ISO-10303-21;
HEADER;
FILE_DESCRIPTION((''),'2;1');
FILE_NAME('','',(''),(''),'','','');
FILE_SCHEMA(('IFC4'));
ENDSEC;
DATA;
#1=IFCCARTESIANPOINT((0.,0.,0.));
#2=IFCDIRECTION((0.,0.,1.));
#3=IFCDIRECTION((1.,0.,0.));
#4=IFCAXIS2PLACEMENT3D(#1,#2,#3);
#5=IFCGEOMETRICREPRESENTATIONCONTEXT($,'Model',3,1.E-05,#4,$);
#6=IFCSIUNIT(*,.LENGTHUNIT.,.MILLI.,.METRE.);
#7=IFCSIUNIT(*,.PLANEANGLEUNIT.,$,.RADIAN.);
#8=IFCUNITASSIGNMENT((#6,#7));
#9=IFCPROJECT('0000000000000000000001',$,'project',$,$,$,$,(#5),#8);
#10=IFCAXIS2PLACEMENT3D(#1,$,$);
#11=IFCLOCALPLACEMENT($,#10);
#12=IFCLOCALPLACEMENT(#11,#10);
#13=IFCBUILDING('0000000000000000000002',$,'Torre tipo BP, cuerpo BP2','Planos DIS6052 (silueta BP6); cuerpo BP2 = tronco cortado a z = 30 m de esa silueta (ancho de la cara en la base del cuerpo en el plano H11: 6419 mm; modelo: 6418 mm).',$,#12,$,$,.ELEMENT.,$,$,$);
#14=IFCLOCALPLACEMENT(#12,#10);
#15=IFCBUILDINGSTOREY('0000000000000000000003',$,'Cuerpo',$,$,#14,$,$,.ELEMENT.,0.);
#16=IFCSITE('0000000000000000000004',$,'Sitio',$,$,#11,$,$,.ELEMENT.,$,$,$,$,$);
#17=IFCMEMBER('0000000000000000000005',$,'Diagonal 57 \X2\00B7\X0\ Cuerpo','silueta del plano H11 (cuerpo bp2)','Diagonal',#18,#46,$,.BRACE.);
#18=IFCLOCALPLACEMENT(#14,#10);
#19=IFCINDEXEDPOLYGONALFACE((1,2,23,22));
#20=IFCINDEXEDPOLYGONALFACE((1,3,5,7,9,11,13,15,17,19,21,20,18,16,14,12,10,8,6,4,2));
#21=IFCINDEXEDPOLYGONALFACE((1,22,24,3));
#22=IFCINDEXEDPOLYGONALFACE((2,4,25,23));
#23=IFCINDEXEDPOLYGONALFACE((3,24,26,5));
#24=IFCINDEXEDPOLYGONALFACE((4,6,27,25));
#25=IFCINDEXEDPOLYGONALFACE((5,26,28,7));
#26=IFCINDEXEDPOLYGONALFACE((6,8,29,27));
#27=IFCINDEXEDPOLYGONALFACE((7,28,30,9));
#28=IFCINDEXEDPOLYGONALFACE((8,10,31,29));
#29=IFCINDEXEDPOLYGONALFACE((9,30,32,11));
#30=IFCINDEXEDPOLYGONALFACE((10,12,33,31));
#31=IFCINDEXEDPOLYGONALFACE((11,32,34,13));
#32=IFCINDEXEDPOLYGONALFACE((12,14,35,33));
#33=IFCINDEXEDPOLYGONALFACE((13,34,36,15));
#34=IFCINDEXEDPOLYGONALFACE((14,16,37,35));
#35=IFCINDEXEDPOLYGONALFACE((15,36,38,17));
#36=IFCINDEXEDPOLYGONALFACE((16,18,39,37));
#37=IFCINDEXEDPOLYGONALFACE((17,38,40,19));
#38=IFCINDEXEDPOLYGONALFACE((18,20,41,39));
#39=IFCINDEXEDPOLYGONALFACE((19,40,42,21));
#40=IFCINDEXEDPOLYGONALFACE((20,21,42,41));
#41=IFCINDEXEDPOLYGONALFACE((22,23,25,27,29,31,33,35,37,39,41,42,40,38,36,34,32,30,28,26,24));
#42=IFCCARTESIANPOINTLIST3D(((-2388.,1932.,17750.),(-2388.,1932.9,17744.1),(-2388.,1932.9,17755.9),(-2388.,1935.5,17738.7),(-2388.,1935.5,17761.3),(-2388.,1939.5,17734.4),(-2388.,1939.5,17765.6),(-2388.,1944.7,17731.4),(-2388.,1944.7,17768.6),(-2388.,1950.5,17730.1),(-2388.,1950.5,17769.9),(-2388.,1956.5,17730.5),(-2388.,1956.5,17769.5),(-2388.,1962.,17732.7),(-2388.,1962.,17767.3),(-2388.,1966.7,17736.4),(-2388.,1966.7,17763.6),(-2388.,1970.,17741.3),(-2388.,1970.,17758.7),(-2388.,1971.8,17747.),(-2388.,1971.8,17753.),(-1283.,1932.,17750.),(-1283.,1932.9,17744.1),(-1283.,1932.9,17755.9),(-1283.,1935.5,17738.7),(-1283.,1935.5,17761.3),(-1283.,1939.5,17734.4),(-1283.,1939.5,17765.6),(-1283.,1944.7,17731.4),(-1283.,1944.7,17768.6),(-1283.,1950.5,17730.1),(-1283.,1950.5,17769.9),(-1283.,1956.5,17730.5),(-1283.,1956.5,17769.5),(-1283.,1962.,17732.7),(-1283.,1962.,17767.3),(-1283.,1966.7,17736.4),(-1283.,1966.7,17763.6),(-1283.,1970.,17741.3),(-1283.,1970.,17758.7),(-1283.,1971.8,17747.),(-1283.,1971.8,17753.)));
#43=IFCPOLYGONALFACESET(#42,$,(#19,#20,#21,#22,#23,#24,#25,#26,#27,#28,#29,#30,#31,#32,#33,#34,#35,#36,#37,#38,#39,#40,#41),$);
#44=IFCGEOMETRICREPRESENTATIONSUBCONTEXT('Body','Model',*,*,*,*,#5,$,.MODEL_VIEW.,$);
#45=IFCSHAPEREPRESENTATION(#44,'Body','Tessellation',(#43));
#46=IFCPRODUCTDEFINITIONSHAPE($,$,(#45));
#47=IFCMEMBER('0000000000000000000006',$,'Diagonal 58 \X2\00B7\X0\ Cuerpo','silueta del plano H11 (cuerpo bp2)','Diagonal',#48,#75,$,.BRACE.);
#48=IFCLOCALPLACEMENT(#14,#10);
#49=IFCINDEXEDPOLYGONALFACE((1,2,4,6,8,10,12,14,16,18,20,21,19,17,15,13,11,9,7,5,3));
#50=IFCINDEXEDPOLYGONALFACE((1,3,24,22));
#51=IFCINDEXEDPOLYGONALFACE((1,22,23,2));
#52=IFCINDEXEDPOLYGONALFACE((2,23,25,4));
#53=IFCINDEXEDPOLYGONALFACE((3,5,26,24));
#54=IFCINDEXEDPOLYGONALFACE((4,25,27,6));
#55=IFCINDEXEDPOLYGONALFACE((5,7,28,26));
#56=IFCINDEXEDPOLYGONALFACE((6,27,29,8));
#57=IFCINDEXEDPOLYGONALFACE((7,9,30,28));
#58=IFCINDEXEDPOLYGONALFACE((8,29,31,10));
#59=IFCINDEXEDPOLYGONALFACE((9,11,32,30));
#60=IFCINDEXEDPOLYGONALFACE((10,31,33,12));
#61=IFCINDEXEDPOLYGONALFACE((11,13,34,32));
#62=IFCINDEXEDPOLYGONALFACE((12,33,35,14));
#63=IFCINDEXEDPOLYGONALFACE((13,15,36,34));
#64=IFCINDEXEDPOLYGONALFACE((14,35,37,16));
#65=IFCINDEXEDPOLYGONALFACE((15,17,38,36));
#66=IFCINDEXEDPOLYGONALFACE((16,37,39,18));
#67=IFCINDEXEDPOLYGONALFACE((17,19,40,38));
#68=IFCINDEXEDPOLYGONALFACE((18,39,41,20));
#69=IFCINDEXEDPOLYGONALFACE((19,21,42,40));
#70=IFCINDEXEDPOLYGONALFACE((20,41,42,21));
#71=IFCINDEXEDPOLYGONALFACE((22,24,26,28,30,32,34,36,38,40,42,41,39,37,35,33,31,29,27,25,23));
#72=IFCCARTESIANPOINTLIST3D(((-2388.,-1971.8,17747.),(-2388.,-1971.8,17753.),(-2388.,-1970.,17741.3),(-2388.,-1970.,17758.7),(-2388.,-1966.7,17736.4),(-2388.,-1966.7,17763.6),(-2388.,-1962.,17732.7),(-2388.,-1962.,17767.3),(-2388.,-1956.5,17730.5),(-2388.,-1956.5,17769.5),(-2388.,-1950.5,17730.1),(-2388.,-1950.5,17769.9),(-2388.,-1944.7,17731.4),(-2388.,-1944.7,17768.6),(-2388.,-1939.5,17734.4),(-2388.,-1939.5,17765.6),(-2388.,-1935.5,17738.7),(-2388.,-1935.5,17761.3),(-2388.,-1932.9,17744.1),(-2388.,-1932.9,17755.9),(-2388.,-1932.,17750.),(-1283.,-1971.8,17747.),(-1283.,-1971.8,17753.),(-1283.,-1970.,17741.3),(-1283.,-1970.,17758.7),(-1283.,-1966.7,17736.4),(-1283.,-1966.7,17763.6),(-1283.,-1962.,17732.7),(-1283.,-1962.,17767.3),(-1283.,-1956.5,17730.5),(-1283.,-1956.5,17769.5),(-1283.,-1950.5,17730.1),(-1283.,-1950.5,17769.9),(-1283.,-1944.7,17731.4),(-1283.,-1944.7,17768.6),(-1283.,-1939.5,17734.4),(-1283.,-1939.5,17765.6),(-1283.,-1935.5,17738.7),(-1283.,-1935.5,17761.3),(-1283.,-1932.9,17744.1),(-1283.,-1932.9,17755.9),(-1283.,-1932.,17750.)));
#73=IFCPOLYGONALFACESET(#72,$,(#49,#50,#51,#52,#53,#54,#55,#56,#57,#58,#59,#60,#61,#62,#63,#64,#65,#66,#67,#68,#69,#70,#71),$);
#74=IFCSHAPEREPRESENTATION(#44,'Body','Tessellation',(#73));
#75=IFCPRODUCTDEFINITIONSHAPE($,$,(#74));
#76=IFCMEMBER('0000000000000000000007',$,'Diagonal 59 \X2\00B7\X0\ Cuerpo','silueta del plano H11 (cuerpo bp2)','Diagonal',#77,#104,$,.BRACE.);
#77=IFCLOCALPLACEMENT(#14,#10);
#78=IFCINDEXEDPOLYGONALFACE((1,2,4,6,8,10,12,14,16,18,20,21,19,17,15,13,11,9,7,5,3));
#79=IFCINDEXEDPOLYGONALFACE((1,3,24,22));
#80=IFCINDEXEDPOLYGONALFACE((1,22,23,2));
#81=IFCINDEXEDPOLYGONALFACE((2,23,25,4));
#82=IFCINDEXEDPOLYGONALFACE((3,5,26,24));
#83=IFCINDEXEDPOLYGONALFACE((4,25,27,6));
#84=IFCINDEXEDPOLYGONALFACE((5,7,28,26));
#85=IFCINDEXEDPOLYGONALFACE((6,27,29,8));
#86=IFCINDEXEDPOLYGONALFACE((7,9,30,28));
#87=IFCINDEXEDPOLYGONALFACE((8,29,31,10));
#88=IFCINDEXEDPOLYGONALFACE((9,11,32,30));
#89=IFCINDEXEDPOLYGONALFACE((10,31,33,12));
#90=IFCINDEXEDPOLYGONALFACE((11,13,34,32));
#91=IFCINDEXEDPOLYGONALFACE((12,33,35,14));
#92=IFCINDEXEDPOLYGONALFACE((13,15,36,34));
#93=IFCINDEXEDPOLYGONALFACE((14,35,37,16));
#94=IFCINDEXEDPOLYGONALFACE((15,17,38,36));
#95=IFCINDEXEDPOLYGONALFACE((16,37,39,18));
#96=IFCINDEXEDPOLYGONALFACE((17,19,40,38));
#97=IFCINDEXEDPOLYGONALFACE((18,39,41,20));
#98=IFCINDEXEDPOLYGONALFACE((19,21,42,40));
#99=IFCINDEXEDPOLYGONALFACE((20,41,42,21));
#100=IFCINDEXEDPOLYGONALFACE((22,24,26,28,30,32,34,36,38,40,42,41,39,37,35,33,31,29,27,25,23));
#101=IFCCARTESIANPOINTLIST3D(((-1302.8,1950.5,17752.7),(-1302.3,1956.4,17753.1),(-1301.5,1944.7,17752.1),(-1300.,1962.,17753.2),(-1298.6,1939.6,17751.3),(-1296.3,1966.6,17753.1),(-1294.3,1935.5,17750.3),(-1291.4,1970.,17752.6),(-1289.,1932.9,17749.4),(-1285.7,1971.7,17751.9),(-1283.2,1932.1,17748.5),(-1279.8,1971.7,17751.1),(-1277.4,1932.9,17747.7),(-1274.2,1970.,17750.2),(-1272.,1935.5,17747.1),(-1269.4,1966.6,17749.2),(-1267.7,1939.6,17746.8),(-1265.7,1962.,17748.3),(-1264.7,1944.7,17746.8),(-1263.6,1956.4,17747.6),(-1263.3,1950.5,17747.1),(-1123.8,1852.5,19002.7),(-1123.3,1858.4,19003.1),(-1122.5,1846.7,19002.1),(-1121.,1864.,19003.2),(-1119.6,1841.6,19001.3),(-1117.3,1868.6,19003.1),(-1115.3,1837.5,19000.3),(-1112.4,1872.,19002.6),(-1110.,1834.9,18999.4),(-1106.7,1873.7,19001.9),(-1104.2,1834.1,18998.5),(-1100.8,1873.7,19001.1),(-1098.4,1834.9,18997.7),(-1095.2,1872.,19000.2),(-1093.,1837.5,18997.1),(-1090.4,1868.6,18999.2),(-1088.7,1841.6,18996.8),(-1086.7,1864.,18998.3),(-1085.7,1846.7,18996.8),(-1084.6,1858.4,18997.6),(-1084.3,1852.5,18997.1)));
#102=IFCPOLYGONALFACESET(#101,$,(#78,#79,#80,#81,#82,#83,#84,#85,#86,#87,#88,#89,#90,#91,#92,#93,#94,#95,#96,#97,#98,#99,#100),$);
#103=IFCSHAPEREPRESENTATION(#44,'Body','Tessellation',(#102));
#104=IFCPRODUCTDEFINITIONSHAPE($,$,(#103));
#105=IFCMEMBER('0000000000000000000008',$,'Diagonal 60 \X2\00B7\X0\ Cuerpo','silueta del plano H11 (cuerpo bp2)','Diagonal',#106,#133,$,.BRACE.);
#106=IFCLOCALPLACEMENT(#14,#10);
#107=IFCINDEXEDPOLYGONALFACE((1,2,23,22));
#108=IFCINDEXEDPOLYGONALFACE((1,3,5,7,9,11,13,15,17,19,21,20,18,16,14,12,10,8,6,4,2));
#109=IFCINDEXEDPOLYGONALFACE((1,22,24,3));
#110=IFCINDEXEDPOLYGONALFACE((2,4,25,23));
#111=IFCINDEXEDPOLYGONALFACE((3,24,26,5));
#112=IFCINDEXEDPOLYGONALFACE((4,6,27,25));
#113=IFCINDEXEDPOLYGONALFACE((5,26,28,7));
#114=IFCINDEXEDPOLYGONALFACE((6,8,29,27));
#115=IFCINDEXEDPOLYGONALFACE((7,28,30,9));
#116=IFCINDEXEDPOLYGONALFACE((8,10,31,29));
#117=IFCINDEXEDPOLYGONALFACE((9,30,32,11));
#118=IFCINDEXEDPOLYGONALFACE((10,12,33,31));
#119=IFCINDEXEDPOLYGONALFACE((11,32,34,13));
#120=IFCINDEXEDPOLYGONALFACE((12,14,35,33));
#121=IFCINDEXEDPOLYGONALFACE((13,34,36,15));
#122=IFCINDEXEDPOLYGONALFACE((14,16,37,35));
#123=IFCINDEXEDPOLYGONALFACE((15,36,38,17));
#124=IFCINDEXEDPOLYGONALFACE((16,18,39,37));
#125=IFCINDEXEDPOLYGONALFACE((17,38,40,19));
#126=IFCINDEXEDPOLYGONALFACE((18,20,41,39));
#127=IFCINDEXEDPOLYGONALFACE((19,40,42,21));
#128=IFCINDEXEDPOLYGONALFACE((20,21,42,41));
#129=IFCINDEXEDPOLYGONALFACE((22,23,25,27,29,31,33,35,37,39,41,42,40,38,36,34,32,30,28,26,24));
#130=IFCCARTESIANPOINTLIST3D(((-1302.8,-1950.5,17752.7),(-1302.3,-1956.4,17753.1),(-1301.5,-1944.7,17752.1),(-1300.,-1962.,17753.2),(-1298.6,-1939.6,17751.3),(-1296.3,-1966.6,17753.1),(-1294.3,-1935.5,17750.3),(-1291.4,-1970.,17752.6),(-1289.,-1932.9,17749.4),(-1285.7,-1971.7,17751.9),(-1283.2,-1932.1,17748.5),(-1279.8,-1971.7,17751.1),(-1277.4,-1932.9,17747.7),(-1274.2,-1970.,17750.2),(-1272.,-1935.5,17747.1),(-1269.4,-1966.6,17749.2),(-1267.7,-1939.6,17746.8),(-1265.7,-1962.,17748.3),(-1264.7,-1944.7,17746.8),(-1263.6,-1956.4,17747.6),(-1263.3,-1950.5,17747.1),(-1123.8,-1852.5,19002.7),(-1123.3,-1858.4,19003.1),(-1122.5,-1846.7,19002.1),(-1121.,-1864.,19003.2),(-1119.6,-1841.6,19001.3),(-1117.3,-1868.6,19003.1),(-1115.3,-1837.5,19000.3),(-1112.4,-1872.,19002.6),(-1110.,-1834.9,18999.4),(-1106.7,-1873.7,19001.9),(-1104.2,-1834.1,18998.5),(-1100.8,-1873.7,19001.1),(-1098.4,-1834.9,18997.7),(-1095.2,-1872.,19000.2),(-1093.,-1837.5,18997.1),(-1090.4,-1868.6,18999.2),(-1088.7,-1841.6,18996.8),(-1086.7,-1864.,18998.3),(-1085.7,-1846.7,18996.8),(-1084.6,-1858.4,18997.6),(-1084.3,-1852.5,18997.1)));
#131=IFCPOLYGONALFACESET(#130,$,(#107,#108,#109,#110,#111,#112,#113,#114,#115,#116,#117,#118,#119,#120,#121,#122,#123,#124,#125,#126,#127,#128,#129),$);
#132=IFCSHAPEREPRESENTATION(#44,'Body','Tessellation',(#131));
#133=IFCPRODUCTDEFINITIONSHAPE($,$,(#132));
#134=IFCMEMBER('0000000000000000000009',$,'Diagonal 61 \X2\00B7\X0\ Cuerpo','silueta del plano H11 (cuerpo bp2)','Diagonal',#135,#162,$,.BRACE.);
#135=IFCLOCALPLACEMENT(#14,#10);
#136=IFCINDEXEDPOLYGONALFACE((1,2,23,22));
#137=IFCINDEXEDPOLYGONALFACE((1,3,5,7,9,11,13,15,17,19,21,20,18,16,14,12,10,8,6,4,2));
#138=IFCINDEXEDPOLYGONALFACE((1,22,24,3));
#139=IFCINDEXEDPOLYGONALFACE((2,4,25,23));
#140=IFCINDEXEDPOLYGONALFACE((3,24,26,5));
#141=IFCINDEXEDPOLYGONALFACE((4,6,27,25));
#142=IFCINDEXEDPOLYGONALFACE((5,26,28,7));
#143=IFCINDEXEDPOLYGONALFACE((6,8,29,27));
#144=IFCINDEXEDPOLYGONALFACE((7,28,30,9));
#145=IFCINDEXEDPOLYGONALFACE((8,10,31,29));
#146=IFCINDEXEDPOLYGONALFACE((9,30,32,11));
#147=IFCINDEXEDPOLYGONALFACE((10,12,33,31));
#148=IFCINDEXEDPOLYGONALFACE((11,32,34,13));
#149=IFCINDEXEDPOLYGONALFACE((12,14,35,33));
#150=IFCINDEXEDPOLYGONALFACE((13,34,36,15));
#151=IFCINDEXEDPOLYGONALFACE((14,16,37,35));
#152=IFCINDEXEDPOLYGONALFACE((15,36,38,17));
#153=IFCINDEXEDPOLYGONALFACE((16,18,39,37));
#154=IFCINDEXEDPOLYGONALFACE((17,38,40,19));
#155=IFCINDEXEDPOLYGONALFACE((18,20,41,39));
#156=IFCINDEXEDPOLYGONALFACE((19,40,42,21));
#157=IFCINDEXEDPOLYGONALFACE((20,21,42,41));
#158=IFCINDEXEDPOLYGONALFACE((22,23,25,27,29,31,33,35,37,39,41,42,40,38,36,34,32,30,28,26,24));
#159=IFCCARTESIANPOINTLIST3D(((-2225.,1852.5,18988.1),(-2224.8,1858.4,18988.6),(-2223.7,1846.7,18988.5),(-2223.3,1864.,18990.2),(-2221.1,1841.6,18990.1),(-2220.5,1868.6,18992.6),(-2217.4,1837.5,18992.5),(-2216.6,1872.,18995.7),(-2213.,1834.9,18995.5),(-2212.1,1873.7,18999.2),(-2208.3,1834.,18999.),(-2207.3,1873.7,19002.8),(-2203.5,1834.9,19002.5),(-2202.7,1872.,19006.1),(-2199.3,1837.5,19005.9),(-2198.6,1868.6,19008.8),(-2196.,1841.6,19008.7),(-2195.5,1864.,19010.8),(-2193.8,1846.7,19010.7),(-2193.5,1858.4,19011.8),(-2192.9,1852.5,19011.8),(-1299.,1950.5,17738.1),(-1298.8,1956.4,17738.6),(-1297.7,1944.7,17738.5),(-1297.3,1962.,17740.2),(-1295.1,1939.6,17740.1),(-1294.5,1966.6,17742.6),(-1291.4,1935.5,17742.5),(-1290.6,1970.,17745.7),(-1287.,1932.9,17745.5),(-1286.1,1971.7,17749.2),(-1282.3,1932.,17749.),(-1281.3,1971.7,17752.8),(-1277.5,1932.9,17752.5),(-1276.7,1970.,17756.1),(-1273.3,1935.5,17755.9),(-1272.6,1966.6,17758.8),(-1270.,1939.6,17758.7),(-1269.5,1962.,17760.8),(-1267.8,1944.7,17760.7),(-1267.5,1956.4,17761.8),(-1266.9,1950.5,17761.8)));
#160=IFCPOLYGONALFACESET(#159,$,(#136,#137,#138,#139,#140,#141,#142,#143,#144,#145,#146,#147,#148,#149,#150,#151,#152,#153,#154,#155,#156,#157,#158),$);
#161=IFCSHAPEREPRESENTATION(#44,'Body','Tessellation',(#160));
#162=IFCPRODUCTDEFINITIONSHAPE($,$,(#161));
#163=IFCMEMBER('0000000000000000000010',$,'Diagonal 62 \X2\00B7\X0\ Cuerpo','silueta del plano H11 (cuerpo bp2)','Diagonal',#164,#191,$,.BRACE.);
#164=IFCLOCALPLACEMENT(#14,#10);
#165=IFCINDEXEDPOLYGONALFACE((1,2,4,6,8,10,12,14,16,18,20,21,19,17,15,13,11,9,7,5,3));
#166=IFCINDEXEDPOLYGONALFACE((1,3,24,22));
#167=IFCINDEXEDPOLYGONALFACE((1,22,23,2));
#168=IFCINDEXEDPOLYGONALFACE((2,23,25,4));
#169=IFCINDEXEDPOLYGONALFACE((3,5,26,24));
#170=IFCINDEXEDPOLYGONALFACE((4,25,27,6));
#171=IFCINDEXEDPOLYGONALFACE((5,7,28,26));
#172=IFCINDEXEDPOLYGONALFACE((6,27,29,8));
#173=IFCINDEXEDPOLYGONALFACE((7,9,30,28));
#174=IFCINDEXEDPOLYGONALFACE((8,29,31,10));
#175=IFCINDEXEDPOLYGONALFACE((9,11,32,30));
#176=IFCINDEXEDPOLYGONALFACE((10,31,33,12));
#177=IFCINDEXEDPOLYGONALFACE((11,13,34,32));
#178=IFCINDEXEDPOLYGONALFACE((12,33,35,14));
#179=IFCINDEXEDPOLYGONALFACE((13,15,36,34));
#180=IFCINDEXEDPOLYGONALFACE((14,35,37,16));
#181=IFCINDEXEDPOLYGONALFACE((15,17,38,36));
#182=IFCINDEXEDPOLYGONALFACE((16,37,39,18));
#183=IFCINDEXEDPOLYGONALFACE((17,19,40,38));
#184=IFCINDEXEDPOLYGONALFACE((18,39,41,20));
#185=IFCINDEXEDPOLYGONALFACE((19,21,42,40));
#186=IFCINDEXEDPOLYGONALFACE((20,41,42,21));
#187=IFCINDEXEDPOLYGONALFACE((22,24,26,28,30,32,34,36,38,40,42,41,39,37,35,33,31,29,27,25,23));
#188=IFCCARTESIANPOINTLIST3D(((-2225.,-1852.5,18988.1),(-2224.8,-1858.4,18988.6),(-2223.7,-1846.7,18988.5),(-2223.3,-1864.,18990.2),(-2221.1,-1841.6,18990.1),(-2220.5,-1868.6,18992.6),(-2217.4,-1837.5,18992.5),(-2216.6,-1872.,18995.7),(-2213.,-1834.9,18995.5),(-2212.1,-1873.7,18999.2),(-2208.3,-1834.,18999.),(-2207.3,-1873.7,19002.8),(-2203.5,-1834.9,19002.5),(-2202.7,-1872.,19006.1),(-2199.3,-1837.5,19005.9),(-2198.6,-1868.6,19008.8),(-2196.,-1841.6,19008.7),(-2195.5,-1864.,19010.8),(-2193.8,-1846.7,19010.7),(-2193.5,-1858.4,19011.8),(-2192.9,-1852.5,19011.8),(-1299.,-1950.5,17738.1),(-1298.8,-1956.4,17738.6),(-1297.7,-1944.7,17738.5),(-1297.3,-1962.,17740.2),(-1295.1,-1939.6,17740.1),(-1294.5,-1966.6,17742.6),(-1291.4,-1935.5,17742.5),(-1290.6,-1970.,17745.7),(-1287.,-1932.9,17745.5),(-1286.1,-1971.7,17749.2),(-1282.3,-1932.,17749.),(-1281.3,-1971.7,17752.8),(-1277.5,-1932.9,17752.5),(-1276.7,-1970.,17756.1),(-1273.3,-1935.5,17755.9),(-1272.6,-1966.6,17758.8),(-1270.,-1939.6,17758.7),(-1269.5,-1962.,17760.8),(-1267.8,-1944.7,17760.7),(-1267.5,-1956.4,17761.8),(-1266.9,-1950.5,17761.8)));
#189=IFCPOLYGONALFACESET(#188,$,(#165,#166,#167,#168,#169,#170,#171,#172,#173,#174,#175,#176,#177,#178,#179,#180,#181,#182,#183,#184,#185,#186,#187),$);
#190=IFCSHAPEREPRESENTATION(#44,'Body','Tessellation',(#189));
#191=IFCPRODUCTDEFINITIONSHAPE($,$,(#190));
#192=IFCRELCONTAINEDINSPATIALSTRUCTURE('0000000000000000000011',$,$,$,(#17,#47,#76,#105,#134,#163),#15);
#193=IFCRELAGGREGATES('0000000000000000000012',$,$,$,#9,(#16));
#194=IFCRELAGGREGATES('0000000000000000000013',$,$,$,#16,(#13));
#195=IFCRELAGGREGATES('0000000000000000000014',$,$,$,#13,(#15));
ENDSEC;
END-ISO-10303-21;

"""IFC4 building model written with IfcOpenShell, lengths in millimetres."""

from ifc_helpers import new_model, si_unit, frame, origin, origin_with_axes, place, context, subcontext, project, spatial, circle, extrude, element, save


model = new_model("IFC4")

# Units and contexts
model_context = context("Model", 3, precision=1e-05, world=origin_with_axes())
body_context = subcontext(model_context, "Body", "Model", "MODEL_VIEW")
ifc_project = project(units=[si_unit("LENGTHUNIT", "METRE", prefix="MILLI"), si_unit("PLANEANGLEUNIT", "RADIAN")], contexts=[model_context])

# Site, building, storey
site_placement = place(None, origin())
site = spatial("IfcSite", under=ifc_project, at=site_placement, Name="Sitio", CompositionType="ELEMENT")
building_placement = place(site_placement, origin())
building = spatial("IfcBuilding", under=site, at=building_placement, Name="Torre tipo BP, cuerpo BP2", Description="Planos DIS6052 (silueta BP6); cuerpo BP2 = tronco cortado a z = 30 m de esa silueta (ancho de la cara en la base del cuerpo en el plano H11: 6419 mm; modelo: 6418 mm).", CompositionType="ELEMENT")
storey_placement = place(building_placement, origin())
storey = spatial("IfcBuildingStorey", under=building, at=storey_placement, Name="Cuerpo", CompositionType="ELEMENT", Elevation=0.0)

# Members
for number, where, z_axis, x_axis, name in (
    (1, (-2388.0, 1952.0, 17750.0), (1.0, 0.0, 0.0), (0.0, -1.0, 0.0), "Diagonal 57 · Cuerpo"),
    (2, (-2388.0, -1952.0, 17750.0), (1.0, 0.0, 0.0), (0.0, 1.0, 0.0), "Diagonal 58 · Cuerpo"),
):
    element("IfcMember", number, at=place(storey_placement, frame(where, z_axis=z_axis, x_axis=x_axis)), inside=storey, Name=name, Description="silueta del plano H11 (cuerpo bp2)", ObjectType="Diagonal", PredefinedType="BRACE", context=body_context, shape_type="SweptSolid", body=[
        extrude(circle(Radius=20.0), None, (0.0, 0.0, 1.0), 1105.0),
    ])
for number, where, z_axis, x_axis, name in (
    (3, (-1283.0, 1952.0, 17750.0), (0.141329, -0.077376, 0.986934), (-0.010968, -0.997002, -0.076594), "Diagonal 59 · Cuerpo"),
    (4, (-1283.0, -1952.0, 17750.0), (0.141329, 0.077376, 0.986934), (-0.010968, 0.997002, -0.076594), "Diagonal 60 · Cuerpo"),
):
    element("IfcMember", number, at=place(storey_placement, frame(where, z_axis=z_axis, x_axis=x_axis)), inside=storey, Name=name, Description="silueta del plano H11 (cuerpo bp2)", ObjectType="Diagonal", PredefinedType="BRACE", context=body_context, shape_type="SweptSolid", body=[
        extrude(circle(Radius=20.0), None, (0.0, 0.0, 1.0), 1266.5),
    ])
for number, where, z_axis, x_axis, name in (
    (5, (-2209.0, 1854.0, 19000.0), (0.594081, 0.062872, -0.801945), (0.037425, -0.998022, -0.05052), "Diagonal 61 · Cuerpo"),
    (6, (-2209.0, -1854.0, 19000.0), (0.594081, -0.062872, -0.801945), (0.037425, 0.998022, -0.05052), "Diagonal 62 · Cuerpo"),
):
    element("IfcMember", number, at=place(storey_placement, frame(where, z_axis=z_axis, x_axis=x_axis)), inside=storey, Name=name, Description="silueta del plano H11 (cuerpo bp2)", ObjectType="Diagonal", PredefinedType="BRACE", context=body_context, shape_type="SweptSolid", body=[
        extrude(circle(Radius=20.0), None, (0.0, 0.0, 1.0), 1558.7),
    ])

save(model, "model.ifc")
